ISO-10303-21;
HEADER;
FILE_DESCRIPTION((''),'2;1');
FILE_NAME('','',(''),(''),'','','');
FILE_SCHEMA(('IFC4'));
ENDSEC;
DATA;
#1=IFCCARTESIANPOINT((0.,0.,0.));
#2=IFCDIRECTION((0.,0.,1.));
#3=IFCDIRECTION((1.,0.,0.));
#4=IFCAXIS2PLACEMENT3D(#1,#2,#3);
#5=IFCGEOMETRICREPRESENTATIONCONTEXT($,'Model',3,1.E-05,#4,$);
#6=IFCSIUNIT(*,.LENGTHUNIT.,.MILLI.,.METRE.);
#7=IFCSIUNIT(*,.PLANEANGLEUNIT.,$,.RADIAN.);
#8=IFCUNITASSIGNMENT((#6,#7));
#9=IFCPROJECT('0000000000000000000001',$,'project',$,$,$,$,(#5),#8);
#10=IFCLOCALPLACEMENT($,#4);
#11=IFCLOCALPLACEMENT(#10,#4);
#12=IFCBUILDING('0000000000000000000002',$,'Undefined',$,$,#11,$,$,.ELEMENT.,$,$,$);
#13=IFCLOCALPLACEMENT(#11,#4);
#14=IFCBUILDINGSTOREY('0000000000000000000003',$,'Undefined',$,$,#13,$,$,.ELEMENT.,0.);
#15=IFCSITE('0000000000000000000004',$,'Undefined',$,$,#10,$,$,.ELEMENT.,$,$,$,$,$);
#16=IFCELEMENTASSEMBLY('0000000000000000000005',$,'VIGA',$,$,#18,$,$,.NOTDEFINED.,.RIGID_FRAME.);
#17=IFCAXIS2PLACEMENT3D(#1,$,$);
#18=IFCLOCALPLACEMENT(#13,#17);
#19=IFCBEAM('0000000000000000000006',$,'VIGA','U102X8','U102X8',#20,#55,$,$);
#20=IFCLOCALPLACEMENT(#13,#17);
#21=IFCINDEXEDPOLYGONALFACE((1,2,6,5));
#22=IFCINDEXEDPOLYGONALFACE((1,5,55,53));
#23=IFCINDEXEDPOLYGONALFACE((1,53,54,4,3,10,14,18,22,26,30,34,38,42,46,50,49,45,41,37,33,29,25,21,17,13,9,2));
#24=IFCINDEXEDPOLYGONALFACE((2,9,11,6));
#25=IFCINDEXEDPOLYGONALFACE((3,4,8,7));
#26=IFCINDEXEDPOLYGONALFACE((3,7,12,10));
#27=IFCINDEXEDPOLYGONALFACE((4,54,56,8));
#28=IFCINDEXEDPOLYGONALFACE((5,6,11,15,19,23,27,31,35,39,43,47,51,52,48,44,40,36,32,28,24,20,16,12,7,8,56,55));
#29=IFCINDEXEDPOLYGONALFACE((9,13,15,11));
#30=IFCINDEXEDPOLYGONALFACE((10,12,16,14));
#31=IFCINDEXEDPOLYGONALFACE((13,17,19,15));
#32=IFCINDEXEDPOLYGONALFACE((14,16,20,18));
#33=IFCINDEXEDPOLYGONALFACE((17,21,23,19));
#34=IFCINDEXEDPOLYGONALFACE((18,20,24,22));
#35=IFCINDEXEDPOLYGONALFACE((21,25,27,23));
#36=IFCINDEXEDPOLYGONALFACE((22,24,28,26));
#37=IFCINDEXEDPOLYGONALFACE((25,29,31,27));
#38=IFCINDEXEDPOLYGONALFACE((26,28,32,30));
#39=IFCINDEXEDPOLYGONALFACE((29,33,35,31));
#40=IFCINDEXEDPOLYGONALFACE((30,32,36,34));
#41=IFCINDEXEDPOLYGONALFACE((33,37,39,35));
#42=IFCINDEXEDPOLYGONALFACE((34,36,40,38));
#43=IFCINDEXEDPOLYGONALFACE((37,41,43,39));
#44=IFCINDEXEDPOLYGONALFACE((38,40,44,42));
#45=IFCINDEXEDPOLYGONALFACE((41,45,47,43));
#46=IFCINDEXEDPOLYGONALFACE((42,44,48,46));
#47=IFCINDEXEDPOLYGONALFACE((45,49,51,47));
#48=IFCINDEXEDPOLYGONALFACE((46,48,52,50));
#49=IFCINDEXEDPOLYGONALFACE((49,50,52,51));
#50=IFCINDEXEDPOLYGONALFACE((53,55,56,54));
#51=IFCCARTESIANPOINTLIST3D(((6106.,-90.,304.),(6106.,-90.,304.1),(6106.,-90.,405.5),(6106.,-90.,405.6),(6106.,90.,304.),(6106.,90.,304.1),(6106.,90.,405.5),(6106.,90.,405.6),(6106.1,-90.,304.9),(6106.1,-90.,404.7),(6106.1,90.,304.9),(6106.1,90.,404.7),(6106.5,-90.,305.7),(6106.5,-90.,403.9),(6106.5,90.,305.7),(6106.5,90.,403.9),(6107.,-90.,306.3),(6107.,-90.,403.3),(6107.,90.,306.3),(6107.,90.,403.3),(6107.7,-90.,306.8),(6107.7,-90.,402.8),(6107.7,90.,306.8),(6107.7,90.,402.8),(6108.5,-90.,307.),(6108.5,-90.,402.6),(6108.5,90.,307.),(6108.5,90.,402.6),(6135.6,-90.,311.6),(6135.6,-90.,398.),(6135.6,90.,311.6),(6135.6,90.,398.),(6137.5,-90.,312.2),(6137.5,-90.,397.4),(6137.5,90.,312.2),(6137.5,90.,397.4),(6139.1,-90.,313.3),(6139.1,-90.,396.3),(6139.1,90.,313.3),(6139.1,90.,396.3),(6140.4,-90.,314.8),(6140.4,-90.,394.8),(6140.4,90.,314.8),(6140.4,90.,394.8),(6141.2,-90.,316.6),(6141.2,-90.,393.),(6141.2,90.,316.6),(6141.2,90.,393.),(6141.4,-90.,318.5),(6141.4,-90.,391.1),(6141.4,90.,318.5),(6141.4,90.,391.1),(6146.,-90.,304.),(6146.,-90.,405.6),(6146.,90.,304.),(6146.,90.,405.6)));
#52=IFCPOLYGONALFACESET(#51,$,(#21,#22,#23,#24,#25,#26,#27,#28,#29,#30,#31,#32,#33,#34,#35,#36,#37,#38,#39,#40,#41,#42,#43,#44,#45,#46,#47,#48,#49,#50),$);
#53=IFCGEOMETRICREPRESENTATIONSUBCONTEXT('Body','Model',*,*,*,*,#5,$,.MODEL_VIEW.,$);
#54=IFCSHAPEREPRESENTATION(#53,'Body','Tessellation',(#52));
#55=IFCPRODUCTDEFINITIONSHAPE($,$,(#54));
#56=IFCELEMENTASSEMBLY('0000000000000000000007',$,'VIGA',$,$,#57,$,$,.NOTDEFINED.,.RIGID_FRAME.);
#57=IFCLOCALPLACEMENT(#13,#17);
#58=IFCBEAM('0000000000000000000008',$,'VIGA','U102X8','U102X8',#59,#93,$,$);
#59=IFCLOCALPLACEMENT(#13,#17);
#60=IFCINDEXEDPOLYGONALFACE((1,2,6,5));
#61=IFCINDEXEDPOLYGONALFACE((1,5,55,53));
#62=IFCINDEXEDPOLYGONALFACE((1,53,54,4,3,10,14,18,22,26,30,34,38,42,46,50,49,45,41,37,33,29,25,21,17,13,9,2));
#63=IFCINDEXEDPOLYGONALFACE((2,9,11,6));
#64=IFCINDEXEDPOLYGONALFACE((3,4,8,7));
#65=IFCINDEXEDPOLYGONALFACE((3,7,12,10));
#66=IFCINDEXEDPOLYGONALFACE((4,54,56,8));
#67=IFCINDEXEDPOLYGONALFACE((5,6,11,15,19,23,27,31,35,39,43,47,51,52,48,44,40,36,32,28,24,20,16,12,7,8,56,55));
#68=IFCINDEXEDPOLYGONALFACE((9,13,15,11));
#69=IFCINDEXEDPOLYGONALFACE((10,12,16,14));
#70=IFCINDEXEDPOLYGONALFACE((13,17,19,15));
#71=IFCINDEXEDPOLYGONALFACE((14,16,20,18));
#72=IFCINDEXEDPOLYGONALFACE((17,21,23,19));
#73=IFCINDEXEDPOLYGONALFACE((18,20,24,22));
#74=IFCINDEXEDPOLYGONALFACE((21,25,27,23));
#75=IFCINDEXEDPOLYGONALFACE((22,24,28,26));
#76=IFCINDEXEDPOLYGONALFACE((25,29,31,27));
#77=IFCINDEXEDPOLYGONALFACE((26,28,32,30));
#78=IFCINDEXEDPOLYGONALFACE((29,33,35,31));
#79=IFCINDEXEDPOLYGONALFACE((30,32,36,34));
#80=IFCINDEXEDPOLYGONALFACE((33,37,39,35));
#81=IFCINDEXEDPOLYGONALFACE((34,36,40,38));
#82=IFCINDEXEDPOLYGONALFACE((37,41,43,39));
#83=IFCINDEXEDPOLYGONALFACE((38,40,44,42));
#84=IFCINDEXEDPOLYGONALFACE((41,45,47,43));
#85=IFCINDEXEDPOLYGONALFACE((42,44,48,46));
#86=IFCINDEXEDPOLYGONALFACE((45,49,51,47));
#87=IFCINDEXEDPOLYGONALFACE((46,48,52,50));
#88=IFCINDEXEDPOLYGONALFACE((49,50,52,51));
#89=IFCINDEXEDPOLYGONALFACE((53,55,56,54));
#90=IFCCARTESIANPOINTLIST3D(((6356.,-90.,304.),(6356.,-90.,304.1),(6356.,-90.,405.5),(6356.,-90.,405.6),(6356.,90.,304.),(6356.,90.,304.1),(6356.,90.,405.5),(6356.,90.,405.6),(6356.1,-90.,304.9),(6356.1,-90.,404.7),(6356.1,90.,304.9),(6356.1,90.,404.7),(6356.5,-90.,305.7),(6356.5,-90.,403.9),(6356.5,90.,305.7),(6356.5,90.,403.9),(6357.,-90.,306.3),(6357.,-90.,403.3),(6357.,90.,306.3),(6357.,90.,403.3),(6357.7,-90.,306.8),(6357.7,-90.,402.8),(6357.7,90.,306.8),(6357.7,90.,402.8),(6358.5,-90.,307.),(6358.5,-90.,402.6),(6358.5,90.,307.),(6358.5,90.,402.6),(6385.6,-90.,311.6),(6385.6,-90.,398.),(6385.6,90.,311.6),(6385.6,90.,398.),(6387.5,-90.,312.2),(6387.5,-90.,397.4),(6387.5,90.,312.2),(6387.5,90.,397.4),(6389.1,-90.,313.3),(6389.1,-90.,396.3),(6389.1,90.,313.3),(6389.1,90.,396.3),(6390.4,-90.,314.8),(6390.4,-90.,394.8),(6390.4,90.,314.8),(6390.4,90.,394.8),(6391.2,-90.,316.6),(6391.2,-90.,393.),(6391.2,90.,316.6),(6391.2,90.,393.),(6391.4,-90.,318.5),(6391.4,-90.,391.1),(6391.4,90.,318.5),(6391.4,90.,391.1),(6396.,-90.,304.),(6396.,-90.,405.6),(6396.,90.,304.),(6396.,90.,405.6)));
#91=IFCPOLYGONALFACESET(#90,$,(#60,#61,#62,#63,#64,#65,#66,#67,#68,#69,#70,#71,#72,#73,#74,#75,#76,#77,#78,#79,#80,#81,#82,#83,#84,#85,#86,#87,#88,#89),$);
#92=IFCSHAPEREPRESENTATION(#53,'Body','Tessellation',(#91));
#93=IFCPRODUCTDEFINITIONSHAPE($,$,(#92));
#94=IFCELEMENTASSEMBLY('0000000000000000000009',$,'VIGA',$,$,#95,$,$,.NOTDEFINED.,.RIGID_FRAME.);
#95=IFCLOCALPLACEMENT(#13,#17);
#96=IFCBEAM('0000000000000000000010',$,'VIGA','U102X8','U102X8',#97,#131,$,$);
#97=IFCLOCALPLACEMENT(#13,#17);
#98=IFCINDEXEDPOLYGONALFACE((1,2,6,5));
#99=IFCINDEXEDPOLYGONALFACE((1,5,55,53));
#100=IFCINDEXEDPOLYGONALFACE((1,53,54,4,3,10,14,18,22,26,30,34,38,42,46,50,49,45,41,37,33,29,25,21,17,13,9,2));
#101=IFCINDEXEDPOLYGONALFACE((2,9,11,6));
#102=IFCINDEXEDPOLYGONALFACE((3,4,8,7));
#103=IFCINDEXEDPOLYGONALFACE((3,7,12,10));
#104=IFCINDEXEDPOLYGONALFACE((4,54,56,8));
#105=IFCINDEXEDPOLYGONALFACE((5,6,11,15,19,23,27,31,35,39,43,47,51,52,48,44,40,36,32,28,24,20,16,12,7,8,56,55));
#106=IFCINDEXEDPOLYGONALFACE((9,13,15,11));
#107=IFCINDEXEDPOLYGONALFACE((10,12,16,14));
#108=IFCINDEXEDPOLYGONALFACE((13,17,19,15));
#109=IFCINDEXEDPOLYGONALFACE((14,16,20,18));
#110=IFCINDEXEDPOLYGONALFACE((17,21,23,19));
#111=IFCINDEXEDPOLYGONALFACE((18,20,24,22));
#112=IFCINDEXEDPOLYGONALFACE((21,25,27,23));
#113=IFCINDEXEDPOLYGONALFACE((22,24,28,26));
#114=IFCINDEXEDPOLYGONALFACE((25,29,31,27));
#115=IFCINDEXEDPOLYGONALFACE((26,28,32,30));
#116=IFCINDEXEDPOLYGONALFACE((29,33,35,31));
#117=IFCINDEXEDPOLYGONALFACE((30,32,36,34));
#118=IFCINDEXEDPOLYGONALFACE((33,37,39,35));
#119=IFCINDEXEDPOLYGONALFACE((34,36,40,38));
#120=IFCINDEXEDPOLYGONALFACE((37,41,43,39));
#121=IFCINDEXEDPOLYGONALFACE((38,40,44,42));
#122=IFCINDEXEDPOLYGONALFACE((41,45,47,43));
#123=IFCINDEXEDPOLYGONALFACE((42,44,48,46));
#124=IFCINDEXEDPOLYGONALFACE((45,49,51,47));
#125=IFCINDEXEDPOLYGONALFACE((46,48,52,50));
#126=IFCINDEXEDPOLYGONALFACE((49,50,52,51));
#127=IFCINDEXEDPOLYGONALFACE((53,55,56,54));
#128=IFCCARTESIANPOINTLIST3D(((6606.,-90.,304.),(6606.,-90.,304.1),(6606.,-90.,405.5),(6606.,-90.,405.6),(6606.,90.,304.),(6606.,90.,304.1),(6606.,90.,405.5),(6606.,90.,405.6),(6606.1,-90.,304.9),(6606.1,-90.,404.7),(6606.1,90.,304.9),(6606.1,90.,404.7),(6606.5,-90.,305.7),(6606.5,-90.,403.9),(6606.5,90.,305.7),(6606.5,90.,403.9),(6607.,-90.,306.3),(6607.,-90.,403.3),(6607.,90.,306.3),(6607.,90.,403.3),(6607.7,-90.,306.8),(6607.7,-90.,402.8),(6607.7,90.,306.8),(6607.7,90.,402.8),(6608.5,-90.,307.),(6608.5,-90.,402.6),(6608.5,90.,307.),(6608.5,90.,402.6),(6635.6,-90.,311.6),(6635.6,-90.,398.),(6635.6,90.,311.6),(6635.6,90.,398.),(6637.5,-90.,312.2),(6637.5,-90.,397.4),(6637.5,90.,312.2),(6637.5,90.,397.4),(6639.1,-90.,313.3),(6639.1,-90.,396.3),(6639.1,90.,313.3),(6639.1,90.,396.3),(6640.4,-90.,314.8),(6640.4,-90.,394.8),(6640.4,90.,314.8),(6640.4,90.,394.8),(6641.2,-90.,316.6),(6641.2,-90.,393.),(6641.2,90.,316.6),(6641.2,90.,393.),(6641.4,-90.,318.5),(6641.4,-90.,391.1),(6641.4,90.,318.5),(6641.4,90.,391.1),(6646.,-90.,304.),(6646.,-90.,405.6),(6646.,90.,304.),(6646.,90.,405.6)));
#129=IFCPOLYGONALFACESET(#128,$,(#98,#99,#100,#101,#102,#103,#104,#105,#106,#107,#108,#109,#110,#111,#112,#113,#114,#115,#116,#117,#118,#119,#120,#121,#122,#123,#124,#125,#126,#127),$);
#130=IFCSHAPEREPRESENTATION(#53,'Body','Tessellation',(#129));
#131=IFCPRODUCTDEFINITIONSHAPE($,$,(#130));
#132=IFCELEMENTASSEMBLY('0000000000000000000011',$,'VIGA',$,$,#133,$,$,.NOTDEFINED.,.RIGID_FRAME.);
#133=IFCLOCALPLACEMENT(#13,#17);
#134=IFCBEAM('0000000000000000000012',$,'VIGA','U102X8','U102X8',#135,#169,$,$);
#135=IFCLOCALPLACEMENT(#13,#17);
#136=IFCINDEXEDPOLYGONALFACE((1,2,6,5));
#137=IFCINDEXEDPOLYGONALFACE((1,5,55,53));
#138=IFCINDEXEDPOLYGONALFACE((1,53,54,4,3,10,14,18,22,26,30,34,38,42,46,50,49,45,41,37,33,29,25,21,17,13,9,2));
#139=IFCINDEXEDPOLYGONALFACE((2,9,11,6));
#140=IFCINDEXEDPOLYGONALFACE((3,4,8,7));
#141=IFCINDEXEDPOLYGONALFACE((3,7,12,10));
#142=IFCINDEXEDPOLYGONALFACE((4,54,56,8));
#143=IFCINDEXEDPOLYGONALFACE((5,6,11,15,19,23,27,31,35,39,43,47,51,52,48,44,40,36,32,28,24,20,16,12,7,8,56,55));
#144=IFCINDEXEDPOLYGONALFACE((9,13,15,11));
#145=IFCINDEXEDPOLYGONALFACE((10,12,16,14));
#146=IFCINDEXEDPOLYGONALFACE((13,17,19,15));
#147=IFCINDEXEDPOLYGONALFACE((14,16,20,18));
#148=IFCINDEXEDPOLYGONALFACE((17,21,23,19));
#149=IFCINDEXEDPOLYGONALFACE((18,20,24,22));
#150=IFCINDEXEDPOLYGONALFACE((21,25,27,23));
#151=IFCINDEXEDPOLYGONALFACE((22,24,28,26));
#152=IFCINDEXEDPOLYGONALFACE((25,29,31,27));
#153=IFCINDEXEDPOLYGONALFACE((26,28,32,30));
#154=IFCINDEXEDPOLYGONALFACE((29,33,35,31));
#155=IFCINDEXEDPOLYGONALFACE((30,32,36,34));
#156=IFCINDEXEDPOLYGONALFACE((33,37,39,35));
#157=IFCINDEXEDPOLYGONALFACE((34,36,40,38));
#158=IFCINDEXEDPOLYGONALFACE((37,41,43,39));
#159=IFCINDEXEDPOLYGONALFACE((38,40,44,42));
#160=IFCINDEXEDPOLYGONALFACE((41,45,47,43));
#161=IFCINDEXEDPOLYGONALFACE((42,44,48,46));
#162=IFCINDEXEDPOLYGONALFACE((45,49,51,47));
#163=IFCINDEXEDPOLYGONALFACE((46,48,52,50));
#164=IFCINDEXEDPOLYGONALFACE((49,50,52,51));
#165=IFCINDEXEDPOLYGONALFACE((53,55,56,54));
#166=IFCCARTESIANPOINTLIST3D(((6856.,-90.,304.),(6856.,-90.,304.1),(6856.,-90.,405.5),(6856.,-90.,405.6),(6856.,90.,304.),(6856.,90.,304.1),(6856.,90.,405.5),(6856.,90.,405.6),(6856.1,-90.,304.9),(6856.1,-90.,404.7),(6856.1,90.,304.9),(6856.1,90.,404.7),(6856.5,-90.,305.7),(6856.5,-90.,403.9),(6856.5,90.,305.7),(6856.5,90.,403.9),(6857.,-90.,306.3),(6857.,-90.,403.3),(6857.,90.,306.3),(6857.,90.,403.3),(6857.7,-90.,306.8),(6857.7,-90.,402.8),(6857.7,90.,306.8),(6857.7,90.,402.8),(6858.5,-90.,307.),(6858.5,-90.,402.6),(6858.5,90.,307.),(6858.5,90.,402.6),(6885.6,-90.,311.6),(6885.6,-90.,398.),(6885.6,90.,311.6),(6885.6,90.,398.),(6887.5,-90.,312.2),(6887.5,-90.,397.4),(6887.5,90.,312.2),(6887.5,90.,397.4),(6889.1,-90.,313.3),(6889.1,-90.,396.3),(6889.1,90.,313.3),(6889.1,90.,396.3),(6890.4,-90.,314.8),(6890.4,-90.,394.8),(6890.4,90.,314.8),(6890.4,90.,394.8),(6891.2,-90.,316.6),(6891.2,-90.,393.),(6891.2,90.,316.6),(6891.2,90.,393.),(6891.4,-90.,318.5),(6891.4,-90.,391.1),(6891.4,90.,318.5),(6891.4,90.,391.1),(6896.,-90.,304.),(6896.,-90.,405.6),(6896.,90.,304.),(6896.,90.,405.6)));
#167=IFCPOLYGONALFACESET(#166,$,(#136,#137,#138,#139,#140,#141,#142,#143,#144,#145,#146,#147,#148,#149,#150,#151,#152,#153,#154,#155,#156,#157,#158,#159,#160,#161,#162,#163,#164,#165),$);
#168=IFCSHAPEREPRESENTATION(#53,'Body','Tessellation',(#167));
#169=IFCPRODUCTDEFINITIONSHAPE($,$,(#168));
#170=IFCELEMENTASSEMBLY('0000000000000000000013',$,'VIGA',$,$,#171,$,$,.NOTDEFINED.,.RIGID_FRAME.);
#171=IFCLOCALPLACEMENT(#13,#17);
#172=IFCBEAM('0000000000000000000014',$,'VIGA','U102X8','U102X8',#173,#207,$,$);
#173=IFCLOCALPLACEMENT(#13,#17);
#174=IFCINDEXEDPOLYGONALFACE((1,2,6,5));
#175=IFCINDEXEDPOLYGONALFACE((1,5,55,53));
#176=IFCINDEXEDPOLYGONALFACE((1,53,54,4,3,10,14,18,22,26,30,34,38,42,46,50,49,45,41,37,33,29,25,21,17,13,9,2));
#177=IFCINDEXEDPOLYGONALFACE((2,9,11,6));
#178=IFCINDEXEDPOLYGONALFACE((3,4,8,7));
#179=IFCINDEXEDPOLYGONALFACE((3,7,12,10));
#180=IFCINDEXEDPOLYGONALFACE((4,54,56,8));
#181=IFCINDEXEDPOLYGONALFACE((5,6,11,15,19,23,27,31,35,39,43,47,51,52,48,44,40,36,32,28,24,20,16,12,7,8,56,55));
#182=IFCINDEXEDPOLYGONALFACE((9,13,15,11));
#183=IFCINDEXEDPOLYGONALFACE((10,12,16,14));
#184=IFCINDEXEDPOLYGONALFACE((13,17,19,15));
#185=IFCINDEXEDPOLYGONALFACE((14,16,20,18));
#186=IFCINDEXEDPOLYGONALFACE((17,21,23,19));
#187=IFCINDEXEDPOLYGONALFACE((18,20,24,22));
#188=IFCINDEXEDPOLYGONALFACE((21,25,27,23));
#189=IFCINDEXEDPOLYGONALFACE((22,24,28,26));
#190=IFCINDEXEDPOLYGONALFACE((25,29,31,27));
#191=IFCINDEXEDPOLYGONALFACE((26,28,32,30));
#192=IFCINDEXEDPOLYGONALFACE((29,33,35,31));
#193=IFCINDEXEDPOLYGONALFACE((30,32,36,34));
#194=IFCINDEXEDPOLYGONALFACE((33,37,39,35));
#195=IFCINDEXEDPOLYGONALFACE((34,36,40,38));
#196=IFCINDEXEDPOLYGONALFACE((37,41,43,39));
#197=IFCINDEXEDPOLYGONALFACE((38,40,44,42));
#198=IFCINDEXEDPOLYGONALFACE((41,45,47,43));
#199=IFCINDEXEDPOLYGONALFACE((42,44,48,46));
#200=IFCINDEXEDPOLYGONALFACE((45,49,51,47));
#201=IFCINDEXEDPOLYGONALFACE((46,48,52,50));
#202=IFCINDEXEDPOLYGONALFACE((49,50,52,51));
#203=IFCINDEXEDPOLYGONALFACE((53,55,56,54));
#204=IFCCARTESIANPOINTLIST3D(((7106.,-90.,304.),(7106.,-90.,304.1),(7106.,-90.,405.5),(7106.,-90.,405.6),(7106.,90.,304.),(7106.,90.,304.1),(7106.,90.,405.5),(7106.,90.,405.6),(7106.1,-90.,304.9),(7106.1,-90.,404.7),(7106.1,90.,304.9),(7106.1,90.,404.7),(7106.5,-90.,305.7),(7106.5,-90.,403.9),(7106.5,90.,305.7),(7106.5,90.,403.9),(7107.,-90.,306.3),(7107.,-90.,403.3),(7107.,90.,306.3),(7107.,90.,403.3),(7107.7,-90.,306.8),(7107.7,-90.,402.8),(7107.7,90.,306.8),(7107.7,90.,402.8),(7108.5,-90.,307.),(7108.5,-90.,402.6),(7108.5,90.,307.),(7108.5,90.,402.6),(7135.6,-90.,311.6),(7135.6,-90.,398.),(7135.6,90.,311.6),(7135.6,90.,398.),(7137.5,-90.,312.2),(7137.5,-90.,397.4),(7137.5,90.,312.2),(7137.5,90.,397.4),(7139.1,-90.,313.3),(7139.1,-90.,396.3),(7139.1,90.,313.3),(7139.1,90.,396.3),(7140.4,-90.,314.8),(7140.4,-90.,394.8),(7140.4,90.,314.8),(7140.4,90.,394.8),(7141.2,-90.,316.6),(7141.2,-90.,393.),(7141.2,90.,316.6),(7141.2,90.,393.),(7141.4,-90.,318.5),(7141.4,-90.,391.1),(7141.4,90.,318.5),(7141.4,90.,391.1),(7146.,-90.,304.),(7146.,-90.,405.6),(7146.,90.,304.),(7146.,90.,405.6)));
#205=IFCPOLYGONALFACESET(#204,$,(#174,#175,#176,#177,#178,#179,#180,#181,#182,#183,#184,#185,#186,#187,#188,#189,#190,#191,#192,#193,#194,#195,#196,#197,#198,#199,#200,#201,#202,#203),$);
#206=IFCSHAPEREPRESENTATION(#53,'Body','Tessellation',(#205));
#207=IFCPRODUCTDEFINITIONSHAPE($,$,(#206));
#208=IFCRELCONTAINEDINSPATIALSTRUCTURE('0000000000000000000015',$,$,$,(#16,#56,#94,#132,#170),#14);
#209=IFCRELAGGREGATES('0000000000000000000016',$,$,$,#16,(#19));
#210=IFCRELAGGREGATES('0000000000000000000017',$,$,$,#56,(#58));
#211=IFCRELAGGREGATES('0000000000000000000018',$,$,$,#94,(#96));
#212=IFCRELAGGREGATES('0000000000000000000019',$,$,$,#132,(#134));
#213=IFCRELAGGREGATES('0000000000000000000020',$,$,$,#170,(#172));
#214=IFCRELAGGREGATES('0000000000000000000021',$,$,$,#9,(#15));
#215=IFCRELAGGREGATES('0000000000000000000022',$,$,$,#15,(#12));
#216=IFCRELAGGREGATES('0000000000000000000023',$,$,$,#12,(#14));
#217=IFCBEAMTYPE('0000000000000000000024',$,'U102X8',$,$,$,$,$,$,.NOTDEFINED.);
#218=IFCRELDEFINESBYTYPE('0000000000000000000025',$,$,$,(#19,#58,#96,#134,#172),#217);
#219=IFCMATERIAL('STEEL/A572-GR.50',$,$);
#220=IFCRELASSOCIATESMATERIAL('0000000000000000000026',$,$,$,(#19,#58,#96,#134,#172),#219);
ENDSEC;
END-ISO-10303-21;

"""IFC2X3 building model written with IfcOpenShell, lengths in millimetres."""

from ifc_helpers import new_model, si_unit, frame, origin_with_axes, origin_2d_with_axis, place, context, subcontext, project, spatial, u_section, extrude, material, type_object, element, aggregate, save


model = new_model("IFC2X3")

# Units and contexts
model_context = context("Model", 3, precision=1e-05, world=origin_with_axes())
body_context = subcontext(model_context, "Body", "Model", "MODEL_VIEW")
ifc_project = project(units=[si_unit("LENGTHUNIT", "METRE", prefix="MILLI"), si_unit("PLANEANGLEUNIT", "RADIAN")], contexts=[model_context])

# Site, building, storey
site_placement = place(None, origin_with_axes())
site = spatial("IfcSite", under=ifc_project, at=site_placement, Name="Undefined", CompositionType="ELEMENT")
building_placement = place(site_placement, origin_with_axes())
building = spatial("IfcBuilding", under=site, at=building_placement, Name="Undefined", CompositionType="ELEMENT")
storey_placement = place(building_placement, origin_with_axes())
storey = spatial("IfcBuildingStorey", under=building, at=storey_placement, Name="Undefined", CompositionType="ELEMENT", Elevation=0.0)

# Element assemblies, beams
ifc_material_1 = material(Name="STEEL/A572-GR.50")
beam_type_1 = type_object("IfcBeamType", Name="U102X8", PredefinedType="NOTDEFINED")
assembly_1_placement = place(storey_placement, origin_with_axes())
assembly_1 = element("IfcElementAssembly", 1, at=assembly_1_placement, inside=storey, Name="VIGA", AssemblyPlace="NOTDEFINED", PredefinedType="RIGID_FRAME")
beam_1_placement = place(assembly_1_placement, frame((6126.0, 90.0, 354.8), z_axis=(0.0, 0.0, 1.0), x_axis=(0.0, -1.0, 0.0)))
beam_1 = element("IfcBeam", 2, at=beam_1_placement, type_object=beam_type_1, material=ifc_material_1, Name="VIGA", Description="U102X8", ObjectType="U102X8", context=body_context, shape_type="SweptSolid", body=[
    extrude(u_section(Depth=101.6, FlangeWidth=40.0, WebThickness=4.6, FlangeThickness=6.0, FilletRadius=7.0, EdgeRadius=3.0, FlangeSlope=0.16839, at=origin_2d_with_axis()), frame((180.0, 0.0, 0.0), z_axis=(-1.0, 0.0, 0.0), x_axis=(0.0, -1.0, 0.0)), (0.0, 0.0, 1.0), 180.0),
])
aggregate(assembly_1, [beam_1])
assembly_2_placement = place(storey_placement, origin_with_axes())
assembly_2 = element("IfcElementAssembly", 3, at=assembly_2_placement, inside=storey, Name="VIGA", AssemblyPlace="NOTDEFINED", PredefinedType="RIGID_FRAME")
beam_2_placement = place(assembly_2_placement, frame((6376.0, 90.0, 354.8), z_axis=(0.0, 0.0, 1.0), x_axis=(0.0, -1.0, 0.0)))
beam_2 = element("IfcBeam", 4, at=beam_2_placement, type_object=beam_type_1, material=ifc_material_1, Name="VIGA", Description="U102X8", ObjectType="U102X8", context=body_context, shape_type="SweptSolid", body=[
    extrude(u_section(Depth=101.6, FlangeWidth=40.0, WebThickness=4.6, FlangeThickness=6.0, FilletRadius=7.0, EdgeRadius=3.0, FlangeSlope=0.16839, at=origin_2d_with_axis()), frame((180.0, 0.0, 0.0), z_axis=(-1.0, 0.0, 0.0), x_axis=(0.0, -1.0, 0.0)), (0.0, 0.0, 1.0), 180.0),
])
aggregate(assembly_2, [beam_2])
assembly_3_placement = place(storey_placement, origin_with_axes())
assembly_3 = element("IfcElementAssembly", 5, at=assembly_3_placement, inside=storey, Name="VIGA", AssemblyPlace="NOTDEFINED", PredefinedType="RIGID_FRAME")
beam_3_placement = place(assembly_3_placement, frame((6626.0, 90.0, 354.8), z_axis=(0.0, 0.0, 1.0), x_axis=(0.0, -1.0, 0.0)))
beam_3 = element("IfcBeam", 6, at=beam_3_placement, type_object=beam_type_1, material=ifc_material_1, Name="VIGA", Description="U102X8", ObjectType="U102X8", context=body_context, shape_type="SweptSolid", body=[
    extrude(u_section(Depth=101.6, FlangeWidth=40.0, WebThickness=4.6, FlangeThickness=6.0, FilletRadius=7.0, EdgeRadius=3.0, FlangeSlope=0.16839, at=origin_2d_with_axis()), frame((180.0, 0.0, 0.0), z_axis=(-1.0, 0.0, 0.0), x_axis=(0.0, -1.0, 0.0)), (0.0, 0.0, 1.0), 180.0),
])
aggregate(assembly_3, [beam_3])
assembly_4_placement = place(storey_placement, origin_with_axes())
assembly_4 = element("IfcElementAssembly", 7, at=assembly_4_placement, inside=storey, Name="VIGA", AssemblyPlace="NOTDEFINED", PredefinedType="RIGID_FRAME")
beam_4_placement = place(assembly_4_placement, frame((6876.0, 90.0, 354.8), z_axis=(0.0, 0.0, 1.0), x_axis=(0.0, -1.0, 0.0)))
beam_4 = element("IfcBeam", 8, at=beam_4_placement, type_object=beam_type_1, material=ifc_material_1, Name="VIGA", Description="U102X8", ObjectType="U102X8", context=body_context, shape_type="SweptSolid", body=[
    extrude(u_section(Depth=101.6, FlangeWidth=40.0, WebThickness=4.6, FlangeThickness=6.0, FilletRadius=7.0, EdgeRadius=3.0, FlangeSlope=0.16839, at=origin_2d_with_axis()), frame((180.0, 0.0, 0.0), z_axis=(-1.0, 0.0, 0.0), x_axis=(0.0, -1.0, 0.0)), (0.0, 0.0, 1.0), 180.0),
])
aggregate(assembly_4, [beam_4])
assembly_5_placement = place(storey_placement, origin_with_axes())
assembly_5 = element("IfcElementAssembly", 9, at=assembly_5_placement, inside=storey, Name="VIGA", AssemblyPlace="NOTDEFINED", PredefinedType="RIGID_FRAME")
beam_5_placement = place(assembly_5_placement, frame((7126.0, 90.0, 354.8), z_axis=(0.0, 0.0, 1.0), x_axis=(0.0, -1.0, 0.0)))
beam_5 = element("IfcBeam", 10, at=beam_5_placement, type_object=beam_type_1, material=ifc_material_1, Name="VIGA", Description="U102X8", ObjectType="U102X8", context=body_context, shape_type="SweptSolid", body=[
    extrude(u_section(Depth=101.6, FlangeWidth=40.0, WebThickness=4.6, FlangeThickness=6.0, FilletRadius=7.0, EdgeRadius=3.0, FlangeSlope=0.16839, at=origin_2d_with_axis()), frame((180.0, 0.0, 0.0), z_axis=(-1.0, 0.0, 0.0), x_axis=(0.0, -1.0, 0.0)), (0.0, 0.0, 1.0), 180.0),
])
aggregate(assembly_5, [beam_5])

save(model, "model.ifc")
